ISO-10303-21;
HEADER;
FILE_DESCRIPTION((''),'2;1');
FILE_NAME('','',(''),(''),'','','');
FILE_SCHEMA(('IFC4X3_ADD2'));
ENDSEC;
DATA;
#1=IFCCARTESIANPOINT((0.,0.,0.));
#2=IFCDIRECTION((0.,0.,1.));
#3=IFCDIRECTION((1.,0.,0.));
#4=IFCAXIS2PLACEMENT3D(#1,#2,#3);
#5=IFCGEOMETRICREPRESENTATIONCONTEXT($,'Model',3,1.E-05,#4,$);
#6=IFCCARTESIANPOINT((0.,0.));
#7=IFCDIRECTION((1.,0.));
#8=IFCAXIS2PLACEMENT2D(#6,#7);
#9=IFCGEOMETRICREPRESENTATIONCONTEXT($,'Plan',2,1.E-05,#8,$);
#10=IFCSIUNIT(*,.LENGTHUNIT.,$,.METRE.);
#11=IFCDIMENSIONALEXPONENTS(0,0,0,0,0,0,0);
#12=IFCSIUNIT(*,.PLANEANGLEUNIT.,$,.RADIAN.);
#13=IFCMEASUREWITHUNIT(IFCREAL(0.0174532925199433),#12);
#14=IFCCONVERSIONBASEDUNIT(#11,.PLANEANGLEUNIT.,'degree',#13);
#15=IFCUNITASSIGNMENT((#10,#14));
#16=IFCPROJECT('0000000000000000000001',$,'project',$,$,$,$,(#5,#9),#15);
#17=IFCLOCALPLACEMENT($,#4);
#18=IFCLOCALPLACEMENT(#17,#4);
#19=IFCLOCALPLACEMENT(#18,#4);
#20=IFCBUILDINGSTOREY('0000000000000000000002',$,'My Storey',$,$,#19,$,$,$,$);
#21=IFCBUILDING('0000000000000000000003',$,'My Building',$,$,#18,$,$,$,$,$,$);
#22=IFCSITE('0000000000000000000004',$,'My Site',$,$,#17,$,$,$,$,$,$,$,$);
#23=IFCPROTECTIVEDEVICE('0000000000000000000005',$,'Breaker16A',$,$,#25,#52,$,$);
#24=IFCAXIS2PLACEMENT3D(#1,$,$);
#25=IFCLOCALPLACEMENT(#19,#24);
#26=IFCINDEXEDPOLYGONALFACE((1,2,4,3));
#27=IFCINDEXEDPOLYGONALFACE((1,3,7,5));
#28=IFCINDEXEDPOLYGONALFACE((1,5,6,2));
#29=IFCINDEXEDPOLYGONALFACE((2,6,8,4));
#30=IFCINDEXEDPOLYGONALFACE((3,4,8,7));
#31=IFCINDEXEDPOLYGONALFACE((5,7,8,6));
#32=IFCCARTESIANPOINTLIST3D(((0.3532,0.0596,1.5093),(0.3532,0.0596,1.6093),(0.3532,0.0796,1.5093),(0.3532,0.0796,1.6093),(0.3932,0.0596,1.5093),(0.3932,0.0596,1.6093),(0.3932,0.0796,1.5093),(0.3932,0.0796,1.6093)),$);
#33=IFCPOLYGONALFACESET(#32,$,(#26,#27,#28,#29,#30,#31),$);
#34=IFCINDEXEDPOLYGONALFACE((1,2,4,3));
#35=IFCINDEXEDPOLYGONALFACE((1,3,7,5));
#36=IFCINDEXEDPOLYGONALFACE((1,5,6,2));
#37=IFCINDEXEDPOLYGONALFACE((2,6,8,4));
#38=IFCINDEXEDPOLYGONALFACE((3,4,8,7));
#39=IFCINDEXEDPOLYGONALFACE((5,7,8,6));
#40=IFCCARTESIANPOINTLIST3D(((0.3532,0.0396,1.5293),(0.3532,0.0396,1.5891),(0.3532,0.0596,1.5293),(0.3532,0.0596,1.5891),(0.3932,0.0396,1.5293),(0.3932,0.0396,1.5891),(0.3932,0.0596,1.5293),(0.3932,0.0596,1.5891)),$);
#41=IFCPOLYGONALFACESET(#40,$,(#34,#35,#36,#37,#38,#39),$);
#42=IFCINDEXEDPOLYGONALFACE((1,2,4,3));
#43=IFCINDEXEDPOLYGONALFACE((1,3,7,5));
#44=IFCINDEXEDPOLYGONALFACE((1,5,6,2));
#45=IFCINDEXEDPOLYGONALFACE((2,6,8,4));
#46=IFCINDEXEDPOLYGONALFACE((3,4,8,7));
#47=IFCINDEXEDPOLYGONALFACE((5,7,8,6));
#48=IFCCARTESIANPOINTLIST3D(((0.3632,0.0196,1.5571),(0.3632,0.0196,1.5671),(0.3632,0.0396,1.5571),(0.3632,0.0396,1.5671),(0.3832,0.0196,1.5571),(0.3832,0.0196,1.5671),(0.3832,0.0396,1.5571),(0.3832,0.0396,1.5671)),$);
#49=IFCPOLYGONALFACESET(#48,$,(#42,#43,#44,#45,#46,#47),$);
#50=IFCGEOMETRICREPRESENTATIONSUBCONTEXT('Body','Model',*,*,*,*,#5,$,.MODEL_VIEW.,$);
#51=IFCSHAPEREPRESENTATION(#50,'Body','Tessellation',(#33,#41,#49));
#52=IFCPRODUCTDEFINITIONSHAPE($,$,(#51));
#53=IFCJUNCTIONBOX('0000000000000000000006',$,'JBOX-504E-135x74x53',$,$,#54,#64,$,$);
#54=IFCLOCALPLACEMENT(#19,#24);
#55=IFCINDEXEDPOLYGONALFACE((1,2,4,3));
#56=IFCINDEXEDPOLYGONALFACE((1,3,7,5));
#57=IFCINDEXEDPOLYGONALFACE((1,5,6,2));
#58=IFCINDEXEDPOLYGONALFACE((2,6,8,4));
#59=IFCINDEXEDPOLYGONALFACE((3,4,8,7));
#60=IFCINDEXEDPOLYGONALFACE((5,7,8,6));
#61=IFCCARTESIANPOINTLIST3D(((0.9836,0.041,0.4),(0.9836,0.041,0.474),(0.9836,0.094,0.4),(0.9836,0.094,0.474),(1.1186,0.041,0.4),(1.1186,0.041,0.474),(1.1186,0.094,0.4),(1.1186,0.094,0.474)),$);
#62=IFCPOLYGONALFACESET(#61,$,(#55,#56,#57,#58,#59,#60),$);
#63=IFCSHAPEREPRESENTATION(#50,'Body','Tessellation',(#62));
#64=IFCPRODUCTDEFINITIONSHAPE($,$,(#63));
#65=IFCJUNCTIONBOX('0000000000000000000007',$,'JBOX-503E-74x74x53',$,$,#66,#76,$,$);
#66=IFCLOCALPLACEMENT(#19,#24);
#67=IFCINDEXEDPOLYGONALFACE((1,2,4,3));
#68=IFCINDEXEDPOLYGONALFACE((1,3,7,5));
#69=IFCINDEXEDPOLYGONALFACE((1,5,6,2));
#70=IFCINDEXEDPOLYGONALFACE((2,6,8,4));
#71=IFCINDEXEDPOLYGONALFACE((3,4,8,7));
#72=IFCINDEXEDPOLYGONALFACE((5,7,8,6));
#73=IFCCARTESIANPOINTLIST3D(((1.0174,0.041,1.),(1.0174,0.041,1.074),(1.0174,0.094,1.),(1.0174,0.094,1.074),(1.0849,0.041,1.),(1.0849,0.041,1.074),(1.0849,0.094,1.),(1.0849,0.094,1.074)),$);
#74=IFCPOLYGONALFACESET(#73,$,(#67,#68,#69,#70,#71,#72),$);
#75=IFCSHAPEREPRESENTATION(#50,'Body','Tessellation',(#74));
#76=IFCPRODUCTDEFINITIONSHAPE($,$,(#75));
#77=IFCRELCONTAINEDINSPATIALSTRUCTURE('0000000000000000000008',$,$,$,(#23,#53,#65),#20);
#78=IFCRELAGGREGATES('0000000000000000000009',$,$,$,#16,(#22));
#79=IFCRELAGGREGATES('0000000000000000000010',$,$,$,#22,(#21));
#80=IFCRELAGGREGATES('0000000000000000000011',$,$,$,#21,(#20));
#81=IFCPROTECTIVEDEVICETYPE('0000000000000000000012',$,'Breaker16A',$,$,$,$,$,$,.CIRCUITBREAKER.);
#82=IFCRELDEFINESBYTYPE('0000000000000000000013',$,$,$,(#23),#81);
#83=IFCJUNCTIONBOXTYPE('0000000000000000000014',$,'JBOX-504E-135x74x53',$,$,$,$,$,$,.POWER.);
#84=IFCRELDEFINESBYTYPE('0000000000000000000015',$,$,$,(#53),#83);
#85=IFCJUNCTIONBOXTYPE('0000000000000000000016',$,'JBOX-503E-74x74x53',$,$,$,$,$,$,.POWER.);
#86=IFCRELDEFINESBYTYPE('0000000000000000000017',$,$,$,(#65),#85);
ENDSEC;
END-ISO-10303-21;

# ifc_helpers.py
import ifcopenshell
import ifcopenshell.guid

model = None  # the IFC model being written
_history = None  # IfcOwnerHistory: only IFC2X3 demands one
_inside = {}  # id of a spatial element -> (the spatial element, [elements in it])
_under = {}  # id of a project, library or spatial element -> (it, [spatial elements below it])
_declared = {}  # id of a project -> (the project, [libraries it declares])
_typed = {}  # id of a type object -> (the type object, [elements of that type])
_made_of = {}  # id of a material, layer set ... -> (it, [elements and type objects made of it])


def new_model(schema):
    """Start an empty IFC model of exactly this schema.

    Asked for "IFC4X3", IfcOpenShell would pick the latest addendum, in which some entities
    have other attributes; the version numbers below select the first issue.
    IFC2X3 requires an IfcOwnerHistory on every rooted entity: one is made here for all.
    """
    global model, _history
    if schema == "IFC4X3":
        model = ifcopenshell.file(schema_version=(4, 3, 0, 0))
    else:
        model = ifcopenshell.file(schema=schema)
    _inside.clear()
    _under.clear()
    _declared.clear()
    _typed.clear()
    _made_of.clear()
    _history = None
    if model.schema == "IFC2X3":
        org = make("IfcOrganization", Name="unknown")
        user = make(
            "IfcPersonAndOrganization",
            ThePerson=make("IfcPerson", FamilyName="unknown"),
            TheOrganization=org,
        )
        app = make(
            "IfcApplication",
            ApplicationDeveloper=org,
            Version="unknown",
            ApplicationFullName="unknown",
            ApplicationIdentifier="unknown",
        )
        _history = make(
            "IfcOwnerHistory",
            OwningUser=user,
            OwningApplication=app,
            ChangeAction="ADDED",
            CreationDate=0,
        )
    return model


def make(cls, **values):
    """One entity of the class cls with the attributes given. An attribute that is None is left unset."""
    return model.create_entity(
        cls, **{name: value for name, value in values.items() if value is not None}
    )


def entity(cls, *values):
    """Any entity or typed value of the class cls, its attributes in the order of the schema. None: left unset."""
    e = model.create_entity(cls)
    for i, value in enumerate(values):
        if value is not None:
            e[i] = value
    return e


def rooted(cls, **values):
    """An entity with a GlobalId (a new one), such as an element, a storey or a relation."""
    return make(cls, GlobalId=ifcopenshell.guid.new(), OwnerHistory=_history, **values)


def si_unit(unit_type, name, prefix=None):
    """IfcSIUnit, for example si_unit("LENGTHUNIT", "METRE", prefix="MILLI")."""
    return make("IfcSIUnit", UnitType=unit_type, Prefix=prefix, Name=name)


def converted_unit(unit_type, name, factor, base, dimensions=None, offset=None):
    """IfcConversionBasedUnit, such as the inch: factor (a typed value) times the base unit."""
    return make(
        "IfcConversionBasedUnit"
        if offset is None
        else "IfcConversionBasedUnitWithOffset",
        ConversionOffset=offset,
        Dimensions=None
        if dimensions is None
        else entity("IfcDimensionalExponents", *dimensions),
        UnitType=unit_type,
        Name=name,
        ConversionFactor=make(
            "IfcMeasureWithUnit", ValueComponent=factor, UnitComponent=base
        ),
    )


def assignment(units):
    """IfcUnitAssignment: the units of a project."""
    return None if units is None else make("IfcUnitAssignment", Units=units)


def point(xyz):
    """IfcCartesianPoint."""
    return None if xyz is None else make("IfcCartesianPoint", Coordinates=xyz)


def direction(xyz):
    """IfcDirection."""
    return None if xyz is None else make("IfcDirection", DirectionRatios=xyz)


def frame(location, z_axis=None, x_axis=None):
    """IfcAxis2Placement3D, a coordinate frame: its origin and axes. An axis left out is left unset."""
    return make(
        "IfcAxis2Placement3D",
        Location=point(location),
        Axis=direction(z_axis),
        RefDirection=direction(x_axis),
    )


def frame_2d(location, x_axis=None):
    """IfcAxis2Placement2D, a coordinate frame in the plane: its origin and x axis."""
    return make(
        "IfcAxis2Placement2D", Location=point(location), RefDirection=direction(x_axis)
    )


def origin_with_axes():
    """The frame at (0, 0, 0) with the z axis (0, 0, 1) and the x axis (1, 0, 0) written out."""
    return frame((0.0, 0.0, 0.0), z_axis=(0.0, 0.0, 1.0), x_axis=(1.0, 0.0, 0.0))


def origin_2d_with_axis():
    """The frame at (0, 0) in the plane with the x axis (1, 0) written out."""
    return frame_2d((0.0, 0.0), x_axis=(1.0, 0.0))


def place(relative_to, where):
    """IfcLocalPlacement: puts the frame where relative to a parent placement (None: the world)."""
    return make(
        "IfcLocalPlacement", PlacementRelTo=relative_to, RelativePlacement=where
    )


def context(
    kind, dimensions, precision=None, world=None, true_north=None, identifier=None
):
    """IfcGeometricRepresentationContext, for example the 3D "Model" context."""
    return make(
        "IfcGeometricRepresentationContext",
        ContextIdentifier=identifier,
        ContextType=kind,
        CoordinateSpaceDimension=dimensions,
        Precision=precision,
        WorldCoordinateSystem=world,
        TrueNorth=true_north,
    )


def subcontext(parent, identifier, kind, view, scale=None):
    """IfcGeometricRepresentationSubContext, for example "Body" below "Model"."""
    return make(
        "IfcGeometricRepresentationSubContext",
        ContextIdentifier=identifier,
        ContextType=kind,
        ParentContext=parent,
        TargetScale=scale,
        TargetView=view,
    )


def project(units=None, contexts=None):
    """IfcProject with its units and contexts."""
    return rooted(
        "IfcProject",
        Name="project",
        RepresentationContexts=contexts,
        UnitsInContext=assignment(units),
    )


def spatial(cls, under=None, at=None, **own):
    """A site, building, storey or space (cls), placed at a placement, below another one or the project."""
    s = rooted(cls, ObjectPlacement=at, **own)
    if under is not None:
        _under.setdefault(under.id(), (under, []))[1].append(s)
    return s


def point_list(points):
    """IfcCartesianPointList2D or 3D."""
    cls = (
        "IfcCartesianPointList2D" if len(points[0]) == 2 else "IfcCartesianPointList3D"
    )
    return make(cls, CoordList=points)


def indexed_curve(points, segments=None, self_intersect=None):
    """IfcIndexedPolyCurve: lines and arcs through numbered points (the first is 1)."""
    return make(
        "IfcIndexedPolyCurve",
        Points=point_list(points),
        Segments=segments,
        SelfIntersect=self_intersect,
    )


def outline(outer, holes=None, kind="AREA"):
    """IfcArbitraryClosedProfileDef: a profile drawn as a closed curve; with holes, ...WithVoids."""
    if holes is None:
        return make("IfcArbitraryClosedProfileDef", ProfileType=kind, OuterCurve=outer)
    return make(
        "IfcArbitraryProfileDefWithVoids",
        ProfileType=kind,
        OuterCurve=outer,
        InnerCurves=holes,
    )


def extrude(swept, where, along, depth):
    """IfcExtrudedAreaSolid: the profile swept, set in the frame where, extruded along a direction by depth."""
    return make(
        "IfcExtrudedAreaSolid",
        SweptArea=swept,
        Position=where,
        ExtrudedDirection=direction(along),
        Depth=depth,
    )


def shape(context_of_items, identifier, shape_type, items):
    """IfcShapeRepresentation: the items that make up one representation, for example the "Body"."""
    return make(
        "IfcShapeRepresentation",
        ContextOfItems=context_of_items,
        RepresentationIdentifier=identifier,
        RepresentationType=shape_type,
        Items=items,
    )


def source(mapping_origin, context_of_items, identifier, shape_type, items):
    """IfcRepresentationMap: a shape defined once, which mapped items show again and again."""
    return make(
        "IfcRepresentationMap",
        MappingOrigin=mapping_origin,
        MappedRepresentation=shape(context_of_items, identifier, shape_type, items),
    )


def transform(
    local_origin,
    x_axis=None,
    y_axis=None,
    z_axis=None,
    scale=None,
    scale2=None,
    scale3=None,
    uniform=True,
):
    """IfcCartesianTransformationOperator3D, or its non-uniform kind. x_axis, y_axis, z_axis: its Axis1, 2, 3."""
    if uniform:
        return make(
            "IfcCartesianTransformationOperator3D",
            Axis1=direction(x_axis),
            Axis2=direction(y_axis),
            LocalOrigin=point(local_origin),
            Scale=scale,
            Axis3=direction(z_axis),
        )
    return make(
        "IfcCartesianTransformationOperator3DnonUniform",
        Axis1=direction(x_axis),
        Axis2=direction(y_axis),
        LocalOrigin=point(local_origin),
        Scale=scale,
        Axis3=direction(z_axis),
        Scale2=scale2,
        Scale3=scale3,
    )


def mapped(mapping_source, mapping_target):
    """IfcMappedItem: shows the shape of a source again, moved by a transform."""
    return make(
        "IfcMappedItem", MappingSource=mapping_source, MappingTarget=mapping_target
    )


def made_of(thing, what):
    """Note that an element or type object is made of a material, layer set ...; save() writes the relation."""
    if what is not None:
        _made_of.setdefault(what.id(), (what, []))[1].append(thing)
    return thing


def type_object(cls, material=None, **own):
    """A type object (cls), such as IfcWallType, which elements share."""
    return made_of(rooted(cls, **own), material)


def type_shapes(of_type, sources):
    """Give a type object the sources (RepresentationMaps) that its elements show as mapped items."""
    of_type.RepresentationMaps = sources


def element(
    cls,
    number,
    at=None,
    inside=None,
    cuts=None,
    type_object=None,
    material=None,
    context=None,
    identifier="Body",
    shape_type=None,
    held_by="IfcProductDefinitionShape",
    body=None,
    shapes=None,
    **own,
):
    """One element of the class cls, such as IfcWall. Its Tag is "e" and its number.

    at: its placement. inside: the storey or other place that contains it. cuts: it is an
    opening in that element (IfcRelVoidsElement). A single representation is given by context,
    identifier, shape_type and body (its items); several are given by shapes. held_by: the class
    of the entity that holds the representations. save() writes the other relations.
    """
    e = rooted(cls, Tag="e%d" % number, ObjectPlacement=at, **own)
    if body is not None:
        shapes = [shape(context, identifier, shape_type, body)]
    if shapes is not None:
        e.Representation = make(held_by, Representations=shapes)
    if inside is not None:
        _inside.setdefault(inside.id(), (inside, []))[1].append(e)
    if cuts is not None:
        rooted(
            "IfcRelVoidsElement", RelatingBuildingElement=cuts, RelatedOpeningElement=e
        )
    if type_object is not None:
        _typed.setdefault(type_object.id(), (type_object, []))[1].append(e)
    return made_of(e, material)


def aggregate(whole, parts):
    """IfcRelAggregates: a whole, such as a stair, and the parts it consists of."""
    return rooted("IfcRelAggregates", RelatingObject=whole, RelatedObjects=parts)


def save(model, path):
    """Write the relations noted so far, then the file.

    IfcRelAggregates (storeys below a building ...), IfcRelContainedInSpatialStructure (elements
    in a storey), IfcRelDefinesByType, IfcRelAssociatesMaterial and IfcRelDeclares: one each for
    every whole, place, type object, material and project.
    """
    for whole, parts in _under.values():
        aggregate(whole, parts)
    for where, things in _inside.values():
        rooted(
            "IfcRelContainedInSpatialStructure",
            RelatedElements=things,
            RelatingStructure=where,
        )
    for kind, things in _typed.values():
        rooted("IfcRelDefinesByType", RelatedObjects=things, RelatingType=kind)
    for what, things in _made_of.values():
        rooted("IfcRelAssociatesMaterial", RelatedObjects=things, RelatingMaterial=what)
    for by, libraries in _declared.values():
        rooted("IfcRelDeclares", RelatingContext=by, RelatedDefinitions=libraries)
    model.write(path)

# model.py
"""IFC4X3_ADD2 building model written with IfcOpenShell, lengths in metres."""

from ifc_helpers import new_model, entity, si_unit, converted_unit, frame, origin_with_axes, origin_2d_with_axis, place, context, subcontext, project, spatial, indexed_curve, outline, extrude, source, transform, mapped, type_object, type_shapes, element, save


model = new_model("IFC4X3_ADD2")

# Units and contexts
model_context = context("Model", 3, precision=1e-05, world=origin_with_axes())
plan_context = context("Plan", 2, precision=1e-05, world=origin_2d_with_axis())
body_context = subcontext(model_context, "Body", "Model", "MODEL_VIEW")
ifc_project = project(units=[si_unit("LENGTHUNIT", "METRE"), converted_unit("PLANEANGLEUNIT", "degree", entity("IfcReal", 0.0174532925199433), si_unit("PLANEANGLEUNIT", "RADIAN"), dimensions=[0, 0, 0, 0, 0, 0, 0])], contexts=[model_context, plan_context])

# Site, building, storey
site_placement = place(None, origin_with_axes())
site = spatial("IfcSite", under=ifc_project, at=site_placement, Name="My Site")
building_placement = place(site_placement, origin_with_axes())
building = spatial("IfcBuilding", under=site, at=building_placement, Name="My Building")
storey_placement = place(building_placement, origin_with_axes())
storey = spatial("IfcBuildingStorey", under=building, at=storey_placement, Name="My Storey")

# Protective device
protective_device_type = type_object("IfcProtectiveDeviceType", Name="Breaker16A", PredefinedType="CIRCUITBREAKER")
shared_shape_1 = source(origin_with_axes(), body_context, "Body", "SweptSolid", [
    extrude(outline(indexed_curve([(0.0, 0.1), (0.04, 0.1), (0.04, 0.0), (0.0, 0.0), (0.0, 0.1)])), frame((0.0, 0.0, 0.0), z_axis=(0.0, -1.0, 0.0), x_axis=(1.0, 0.0, 0.0)), (0.0, 0.0, 1.0), 0.02),
    extrude(outline(indexed_curve([(0.0, 0.02), (0.04, 0.02), (0.04, 0.0798), (0.0, 0.0798), (0.0, 0.02)])), frame((0.0, -0.02, 0.0), z_axis=(0.0, -1.0, 0.0), x_axis=(1.0, 0.0, 0.0)), (0.0, 0.0, 1.0), 0.02),
    extrude(outline(indexed_curve([(0.01, 0.0478), (0.03, 0.0478), (0.03, 0.0578), (0.01, 0.0578), (0.01, 0.0478)])), frame((0.0, -0.04, 0.0), z_axis=(0.0, -1.0, 0.0), x_axis=(1.0, 0.0, 0.0)), (0.0, 0.0, 1.0), 0.02),
])
type_shapes(protective_device_type, [shared_shape_1])
protective_device_placement = place(storey_placement, frame((0.3532, 0.0796, 1.5093), z_axis=(0.0, 0.0, 1.0), x_axis=(1.0, 0.0, 0.0)))
element("IfcProtectiveDevice", 1, at=protective_device_placement, inside=storey, type_object=protective_device_type, Name="Breaker16A", context=body_context, shape_type="MappedRepresentation", body=[
    mapped(shared_shape_1, transform((0.0, 0.0, 0.0), x_axis=(1.0, 0.0, 0.0), y_axis=(0.0, 1.0, 0.0), z_axis=(0.0, 0.0, 1.0), scale=1.0)),
])

# Junction boxes
junction_box_type_1 = type_object("IfcJunctionBoxType", Name="JBOX-504E-135x74x53", PredefinedType="POWER")
shared_shape_2 = source(origin_with_axes(), body_context, "Body", "SweptSolid", [
    extrude(outline(indexed_curve([(0.0, 0.074), (0.135, 0.074), (0.135, 0.0), (0.0, 0.0), (0.0, 0.074)])), frame((0.0, 0.0, 0.0), z_axis=(0.0, -1.0, 0.0), x_axis=(1.0, 0.0, 0.0)), (0.0, 0.0, 1.0), 0.053),
])
type_shapes(junction_box_type_1, [shared_shape_2])
junction_box_1_placement = place(storey_placement, frame((0.9836, 0.094, 0.4), z_axis=(0.0, 0.0, 1.0), x_axis=(1.0, 0.0, 0.0)))
element("IfcJunctionBox", 2, at=junction_box_1_placement, inside=storey, type_object=junction_box_type_1, Name="JBOX-504E-135x74x53", context=body_context, shape_type="MappedRepresentation", body=[
    mapped(shared_shape_2, transform((0.0, 0.0, 0.0), x_axis=(1.0, 0.0, 0.0), y_axis=(0.0, 1.0, 0.0), z_axis=(0.0, 0.0, 1.0), scale=1.0)),
])
junction_box_type_2 = type_object("IfcJunctionBoxType", Name="JBOX-503E-74x74x53", PredefinedType="POWER")
shared_shape_3 = source(origin_with_axes(), body_context, "Body", "SweptSolid", [
    extrude(outline(indexed_curve([(0.0, 0.0), (0.0675, 0.0), (0.0675, 0.074), (0.0, 0.074), (0.0, 0.0)])), frame((0.0, 0.0, 0.0), z_axis=(0.0, -1.0, 0.0), x_axis=(1.0, 0.0, 0.0)), (0.0, 0.0, 1.0), 0.053),
])
type_shapes(junction_box_type_2, [shared_shape_3])
junction_box_2_placement = place(storey_placement, frame((1.0174, 0.094, 1.0), z_axis=(0.0, 0.0, 1.0), x_axis=(1.0, 0.0, 0.0)))
element("IfcJunctionBox", 3, at=junction_box_2_placement, inside=storey, type_object=junction_box_type_2, Name="JBOX-503E-74x74x53", context=body_context, shape_type="MappedRepresentation", body=[
    mapped(shared_shape_3, transform((0.0, 0.0, 0.0), x_axis=(1.0, 0.0, 0.0), y_axis=(0.0, 1.0, 0.0), z_axis=(0.0, 0.0, 1.0), scale=1.0)),
])

save(model, "model.ifc")
